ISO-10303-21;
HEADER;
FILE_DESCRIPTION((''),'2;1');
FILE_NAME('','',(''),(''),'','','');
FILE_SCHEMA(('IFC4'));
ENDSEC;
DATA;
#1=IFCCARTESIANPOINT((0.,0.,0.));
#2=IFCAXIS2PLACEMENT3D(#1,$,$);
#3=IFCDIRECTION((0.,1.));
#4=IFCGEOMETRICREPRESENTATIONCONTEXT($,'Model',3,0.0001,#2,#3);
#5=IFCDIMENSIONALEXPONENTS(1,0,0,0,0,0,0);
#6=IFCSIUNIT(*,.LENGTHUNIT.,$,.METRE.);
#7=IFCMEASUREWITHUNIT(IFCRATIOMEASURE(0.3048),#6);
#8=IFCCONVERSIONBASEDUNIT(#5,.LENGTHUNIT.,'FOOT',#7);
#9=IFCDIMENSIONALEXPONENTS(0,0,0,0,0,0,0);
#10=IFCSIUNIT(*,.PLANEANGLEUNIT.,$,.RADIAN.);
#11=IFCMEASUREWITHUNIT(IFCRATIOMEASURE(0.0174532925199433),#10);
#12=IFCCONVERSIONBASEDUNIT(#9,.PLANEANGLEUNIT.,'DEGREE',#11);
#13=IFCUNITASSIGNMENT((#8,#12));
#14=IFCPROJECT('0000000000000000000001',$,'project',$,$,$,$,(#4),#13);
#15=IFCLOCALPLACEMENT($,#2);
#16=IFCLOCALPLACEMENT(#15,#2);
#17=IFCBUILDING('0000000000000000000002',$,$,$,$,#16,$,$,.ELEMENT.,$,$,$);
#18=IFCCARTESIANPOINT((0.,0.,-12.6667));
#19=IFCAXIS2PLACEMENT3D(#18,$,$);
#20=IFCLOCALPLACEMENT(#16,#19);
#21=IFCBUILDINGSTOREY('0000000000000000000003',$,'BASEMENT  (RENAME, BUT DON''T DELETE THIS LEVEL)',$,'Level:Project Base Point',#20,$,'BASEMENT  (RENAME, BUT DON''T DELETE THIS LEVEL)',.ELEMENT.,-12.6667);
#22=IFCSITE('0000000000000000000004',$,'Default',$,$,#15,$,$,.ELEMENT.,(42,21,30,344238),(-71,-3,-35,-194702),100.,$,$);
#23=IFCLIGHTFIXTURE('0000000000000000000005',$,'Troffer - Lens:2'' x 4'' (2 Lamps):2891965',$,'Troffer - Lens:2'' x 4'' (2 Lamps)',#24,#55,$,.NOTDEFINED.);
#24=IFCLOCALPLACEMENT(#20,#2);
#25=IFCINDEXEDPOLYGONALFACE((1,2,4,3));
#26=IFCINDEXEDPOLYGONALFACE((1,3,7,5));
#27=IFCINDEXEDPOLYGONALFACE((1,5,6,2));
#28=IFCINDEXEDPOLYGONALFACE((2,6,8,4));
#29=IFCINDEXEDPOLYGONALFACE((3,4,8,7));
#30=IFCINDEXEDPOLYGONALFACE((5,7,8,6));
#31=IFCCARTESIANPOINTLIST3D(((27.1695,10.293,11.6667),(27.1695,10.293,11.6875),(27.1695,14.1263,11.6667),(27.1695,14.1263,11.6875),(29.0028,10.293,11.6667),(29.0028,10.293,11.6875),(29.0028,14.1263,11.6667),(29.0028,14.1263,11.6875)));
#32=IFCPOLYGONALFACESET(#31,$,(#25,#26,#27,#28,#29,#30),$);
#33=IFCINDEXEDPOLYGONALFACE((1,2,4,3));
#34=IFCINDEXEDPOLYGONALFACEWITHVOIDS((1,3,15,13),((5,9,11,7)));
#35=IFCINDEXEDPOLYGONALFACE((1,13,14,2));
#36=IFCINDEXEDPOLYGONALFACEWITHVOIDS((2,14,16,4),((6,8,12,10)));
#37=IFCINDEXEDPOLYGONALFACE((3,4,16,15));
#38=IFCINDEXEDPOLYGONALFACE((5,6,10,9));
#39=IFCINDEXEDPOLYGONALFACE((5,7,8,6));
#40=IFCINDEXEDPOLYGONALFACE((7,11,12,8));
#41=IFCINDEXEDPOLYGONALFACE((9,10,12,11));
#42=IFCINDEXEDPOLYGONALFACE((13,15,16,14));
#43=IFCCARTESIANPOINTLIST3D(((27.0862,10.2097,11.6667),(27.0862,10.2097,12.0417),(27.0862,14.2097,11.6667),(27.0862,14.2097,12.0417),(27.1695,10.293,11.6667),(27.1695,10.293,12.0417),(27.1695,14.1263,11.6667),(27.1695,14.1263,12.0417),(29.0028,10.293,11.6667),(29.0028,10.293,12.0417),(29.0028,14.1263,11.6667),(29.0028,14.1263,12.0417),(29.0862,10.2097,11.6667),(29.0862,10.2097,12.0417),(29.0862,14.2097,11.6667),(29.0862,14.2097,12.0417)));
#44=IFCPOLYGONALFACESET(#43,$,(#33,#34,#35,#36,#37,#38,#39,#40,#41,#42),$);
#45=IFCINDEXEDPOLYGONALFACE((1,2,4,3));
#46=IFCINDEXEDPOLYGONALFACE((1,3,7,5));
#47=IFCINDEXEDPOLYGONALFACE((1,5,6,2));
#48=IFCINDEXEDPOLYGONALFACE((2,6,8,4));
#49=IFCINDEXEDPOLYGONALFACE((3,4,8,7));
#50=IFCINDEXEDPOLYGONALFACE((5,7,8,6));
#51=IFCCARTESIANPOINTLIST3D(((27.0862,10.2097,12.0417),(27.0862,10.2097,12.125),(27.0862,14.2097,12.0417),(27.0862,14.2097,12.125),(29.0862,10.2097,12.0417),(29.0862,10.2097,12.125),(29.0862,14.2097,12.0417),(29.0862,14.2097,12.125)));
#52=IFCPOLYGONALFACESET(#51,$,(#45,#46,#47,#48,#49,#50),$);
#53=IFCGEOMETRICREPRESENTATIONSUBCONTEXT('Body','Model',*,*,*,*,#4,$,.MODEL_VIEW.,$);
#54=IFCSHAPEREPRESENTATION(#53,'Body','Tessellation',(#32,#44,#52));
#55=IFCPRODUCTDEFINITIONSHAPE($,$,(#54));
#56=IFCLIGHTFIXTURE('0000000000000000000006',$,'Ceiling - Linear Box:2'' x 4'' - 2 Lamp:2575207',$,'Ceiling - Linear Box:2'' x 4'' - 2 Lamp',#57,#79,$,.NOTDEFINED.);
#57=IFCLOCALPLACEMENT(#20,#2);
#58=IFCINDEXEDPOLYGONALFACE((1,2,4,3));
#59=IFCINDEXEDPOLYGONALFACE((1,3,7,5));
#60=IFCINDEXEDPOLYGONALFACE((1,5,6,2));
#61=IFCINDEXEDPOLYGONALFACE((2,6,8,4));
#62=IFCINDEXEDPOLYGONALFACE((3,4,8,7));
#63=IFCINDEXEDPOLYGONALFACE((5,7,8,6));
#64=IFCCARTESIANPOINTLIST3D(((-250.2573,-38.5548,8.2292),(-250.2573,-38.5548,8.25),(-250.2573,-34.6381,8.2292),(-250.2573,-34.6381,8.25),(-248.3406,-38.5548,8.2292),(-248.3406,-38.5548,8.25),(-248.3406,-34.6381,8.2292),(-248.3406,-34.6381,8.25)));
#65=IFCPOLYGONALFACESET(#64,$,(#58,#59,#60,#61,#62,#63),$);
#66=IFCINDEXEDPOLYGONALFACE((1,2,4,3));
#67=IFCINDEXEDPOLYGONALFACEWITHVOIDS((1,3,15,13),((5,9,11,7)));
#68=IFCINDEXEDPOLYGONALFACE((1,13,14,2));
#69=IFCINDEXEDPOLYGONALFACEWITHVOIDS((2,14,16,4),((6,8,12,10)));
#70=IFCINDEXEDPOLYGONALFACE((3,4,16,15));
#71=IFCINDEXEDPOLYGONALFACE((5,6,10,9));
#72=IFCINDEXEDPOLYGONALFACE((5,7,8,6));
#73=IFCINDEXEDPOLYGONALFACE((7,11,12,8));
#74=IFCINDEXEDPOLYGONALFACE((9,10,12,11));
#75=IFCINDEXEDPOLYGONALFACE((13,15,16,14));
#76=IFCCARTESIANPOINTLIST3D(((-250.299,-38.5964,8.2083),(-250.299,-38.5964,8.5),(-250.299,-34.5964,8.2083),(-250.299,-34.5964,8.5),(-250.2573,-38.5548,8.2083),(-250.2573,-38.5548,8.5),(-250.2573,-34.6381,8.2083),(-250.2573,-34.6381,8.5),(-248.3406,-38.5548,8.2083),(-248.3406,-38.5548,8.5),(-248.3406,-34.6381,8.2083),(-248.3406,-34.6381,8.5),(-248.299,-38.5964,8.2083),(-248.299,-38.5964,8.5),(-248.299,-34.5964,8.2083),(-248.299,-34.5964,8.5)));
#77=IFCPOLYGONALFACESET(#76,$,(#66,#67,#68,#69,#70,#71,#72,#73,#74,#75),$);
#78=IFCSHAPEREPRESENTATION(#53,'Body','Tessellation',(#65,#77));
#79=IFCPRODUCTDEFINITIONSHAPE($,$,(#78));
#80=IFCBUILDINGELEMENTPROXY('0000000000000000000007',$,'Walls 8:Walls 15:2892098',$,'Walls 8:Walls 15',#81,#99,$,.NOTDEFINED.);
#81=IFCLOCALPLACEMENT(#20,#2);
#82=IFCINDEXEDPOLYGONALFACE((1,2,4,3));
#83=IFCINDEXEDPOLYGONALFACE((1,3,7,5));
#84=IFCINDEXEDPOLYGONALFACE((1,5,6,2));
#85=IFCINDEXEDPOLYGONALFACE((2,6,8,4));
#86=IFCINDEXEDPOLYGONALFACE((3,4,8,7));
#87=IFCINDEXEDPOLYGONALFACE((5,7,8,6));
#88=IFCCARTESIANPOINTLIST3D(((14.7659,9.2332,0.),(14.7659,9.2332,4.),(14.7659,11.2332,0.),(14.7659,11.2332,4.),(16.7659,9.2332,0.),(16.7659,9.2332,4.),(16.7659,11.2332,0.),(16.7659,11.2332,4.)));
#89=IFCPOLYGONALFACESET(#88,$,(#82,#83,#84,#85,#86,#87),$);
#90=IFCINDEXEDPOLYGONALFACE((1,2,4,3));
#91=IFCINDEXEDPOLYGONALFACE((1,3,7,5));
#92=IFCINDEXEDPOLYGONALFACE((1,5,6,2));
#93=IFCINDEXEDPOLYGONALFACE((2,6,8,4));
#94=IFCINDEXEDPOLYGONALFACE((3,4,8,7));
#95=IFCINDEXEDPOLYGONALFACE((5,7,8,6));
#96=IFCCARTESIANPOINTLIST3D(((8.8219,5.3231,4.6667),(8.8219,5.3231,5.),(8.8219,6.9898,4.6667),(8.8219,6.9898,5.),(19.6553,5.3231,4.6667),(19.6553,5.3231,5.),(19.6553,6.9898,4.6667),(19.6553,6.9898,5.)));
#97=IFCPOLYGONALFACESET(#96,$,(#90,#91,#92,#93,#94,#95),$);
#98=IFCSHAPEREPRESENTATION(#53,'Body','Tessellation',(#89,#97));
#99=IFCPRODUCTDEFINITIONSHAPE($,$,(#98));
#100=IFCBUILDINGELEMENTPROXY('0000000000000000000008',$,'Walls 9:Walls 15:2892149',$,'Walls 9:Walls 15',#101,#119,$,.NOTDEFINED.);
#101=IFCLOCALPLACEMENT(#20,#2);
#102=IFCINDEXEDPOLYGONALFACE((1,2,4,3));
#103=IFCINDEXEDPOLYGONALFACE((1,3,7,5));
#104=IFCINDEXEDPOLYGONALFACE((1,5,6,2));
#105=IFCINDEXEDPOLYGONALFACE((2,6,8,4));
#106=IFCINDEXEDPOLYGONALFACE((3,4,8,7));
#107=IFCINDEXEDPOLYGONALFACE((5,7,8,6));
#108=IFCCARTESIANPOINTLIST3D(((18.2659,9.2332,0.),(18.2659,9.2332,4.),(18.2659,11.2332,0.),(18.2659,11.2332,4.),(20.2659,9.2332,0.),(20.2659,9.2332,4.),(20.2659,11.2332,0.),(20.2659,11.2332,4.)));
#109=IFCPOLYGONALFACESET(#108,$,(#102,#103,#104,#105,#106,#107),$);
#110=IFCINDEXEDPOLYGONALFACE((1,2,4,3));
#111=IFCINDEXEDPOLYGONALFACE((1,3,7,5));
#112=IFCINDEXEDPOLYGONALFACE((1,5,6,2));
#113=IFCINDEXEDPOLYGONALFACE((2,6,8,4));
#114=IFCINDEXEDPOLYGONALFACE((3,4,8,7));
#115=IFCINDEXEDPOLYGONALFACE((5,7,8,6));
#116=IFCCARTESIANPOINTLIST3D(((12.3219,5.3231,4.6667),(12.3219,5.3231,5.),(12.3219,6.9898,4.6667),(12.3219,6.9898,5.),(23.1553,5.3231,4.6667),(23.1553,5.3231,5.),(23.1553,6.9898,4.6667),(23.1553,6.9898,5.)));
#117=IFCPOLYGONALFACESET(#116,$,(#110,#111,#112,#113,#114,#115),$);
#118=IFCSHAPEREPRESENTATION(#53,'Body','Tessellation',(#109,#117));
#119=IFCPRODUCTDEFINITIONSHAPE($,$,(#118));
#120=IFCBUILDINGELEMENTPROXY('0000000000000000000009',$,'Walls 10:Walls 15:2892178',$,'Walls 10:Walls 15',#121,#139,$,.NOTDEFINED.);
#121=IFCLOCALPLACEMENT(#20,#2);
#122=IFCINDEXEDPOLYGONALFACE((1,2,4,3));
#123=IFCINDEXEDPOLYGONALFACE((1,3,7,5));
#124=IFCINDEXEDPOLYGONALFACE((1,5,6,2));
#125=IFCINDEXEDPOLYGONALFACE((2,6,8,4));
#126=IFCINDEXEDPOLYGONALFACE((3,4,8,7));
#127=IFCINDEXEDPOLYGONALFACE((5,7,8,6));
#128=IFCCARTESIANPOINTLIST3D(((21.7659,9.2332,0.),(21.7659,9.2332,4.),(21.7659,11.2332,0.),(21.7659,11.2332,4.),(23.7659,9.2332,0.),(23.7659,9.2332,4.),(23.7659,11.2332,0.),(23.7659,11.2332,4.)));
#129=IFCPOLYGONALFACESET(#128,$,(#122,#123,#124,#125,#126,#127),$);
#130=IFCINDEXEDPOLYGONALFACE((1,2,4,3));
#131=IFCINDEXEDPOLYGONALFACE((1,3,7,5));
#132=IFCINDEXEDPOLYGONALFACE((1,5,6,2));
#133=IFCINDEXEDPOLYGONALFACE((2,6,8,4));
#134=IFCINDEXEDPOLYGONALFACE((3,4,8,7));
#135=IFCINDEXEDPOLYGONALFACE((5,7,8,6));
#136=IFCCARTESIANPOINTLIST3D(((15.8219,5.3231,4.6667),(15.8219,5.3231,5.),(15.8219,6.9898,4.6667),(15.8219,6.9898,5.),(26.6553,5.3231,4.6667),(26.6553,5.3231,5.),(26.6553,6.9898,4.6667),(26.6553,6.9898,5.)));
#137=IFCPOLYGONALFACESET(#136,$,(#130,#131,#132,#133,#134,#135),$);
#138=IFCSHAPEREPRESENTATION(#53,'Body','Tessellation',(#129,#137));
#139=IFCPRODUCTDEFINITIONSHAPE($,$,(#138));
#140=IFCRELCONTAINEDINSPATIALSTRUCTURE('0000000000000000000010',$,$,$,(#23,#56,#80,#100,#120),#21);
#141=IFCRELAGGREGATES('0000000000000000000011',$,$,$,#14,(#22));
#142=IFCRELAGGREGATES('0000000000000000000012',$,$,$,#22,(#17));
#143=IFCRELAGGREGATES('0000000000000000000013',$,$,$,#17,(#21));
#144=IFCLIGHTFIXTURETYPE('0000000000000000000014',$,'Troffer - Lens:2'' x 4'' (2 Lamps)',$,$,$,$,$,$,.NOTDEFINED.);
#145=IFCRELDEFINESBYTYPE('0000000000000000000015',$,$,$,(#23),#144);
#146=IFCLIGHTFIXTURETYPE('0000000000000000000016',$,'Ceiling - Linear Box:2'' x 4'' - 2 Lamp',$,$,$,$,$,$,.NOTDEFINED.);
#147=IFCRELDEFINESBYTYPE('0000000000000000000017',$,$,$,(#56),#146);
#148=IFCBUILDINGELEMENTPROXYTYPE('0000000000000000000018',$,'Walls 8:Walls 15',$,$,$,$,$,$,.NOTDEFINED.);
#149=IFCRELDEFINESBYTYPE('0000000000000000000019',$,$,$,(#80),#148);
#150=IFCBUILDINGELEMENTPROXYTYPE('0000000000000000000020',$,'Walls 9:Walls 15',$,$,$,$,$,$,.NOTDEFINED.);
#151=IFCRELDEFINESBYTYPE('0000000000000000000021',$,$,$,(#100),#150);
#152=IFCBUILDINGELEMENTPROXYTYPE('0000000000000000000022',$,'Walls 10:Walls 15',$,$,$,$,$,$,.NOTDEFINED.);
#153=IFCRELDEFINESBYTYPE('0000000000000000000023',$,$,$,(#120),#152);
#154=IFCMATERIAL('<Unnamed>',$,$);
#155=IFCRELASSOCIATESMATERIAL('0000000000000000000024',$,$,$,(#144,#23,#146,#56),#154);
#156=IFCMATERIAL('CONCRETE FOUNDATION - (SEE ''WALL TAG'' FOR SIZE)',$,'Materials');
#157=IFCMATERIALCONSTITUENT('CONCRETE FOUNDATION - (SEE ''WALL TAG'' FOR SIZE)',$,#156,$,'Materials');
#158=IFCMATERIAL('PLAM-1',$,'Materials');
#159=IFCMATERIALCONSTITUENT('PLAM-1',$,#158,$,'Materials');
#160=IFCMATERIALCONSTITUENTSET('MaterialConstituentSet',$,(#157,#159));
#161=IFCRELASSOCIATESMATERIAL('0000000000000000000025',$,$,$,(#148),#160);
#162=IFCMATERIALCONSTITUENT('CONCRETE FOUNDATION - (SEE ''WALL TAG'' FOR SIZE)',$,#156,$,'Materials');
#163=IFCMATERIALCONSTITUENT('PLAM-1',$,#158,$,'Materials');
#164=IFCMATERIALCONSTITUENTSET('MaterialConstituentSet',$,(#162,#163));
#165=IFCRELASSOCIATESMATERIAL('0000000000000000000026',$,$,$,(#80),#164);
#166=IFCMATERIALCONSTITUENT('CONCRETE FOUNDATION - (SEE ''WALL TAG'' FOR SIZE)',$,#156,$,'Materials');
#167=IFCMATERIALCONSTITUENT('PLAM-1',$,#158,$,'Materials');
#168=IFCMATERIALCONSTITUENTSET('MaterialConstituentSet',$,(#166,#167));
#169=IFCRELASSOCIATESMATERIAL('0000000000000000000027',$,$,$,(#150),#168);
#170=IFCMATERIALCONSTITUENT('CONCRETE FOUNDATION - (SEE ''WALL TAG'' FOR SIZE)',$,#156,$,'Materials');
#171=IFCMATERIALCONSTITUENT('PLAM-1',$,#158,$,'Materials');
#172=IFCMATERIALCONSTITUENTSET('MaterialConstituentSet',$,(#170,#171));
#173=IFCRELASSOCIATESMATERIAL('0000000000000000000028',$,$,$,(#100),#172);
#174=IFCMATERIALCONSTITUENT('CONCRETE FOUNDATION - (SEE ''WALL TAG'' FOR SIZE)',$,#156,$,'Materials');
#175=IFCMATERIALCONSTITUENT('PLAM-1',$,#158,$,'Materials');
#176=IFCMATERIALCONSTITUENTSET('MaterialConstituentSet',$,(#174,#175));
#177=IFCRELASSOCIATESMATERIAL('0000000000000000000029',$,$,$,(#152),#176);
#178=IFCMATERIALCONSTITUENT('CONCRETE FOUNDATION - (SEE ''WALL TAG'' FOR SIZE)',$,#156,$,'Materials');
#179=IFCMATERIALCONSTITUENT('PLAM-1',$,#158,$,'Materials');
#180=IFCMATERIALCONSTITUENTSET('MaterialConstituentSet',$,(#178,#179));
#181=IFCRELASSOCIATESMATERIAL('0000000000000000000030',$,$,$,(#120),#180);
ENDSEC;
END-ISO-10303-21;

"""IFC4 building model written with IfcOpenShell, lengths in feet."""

from ifc_helpers import new_model, entity, si_unit, converted_unit, direction, frame, frame_2d, origin, origin_2d_with_axis, place, context, subcontext, project, spatial, polyline, rectangle, outline, extrude, source, transform, mapped, material, constituent, constituent_set, type_object, type_shapes, element, save


model = new_model("IFC4")

# Units and contexts
model_context = context("Model", 3, precision=0.0001, world=origin(), true_north=direction((0.0, 1.0)))
body_context = subcontext(model_context, "Body", "Model", "MODEL_VIEW")
ifc_project = project(units=[converted_unit("LENGTHUNIT", "FOOT", entity("IfcRatioMeasure", 0.3048), si_unit("LENGTHUNIT", "METRE"), dimensions=[1, 0, 0, 0, 0, 0, 0]), converted_unit("PLANEANGLEUNIT", "DEGREE", entity("IfcRatioMeasure", 0.0174532925199433), si_unit("PLANEANGLEUNIT", "RADIAN"), dimensions=[0, 0, 0, 0, 0, 0, 0])], contexts=[model_context])

# Site, building, storey
site_placement = place(None, origin())
site = spatial("IfcSite", under=ifc_project, at=site_placement, Name="Default", CompositionType="ELEMENT", RefLatitude=(42, 21, 30, 344238), RefLongitude=(-71, -3, -35, -194702), RefElevation=100.0)
building_placement = place(site_placement, origin())
building = spatial("IfcBuilding", under=site, at=building_placement, CompositionType="ELEMENT")
storey_placement = place(building_placement, frame((0.0, 0.0, -12.6667)))
storey = spatial("IfcBuildingStorey", under=building, at=storey_placement, Name="BASEMENT  (RENAME, BUT DON'T DELETE THIS LEVEL)", ObjectType="Level:Project Base Point", LongName="BASEMENT  (RENAME, BUT DON'T DELETE THIS LEVEL)", CompositionType="ELEMENT", Elevation=-12.6667)

# Shared definitions
ifc_material_1 = material(Name="CONCRETE FOUNDATION - (SEE 'WALL TAG' FOR SIZE)", Category="Materials")
ifc_material_2 = material(Name="PLAM-1", Category="Materials")

# Light fixtures
ifc_material_3 = material(Name="<Unnamed>")
light_fixture_type_1 = type_object("IfcLightFixtureType", Name="Troffer - Lens:2' x 4' (2 Lamps)", PredefinedType="NOTDEFINED", material=ifc_material_3)
shared_shape_1 = source(origin(), body_context, "Body", "SweptSolid", [
    extrude(rectangle(XDim=3.8333, YDim=1.8333, at=origin_2d_with_axis()), frame((2.0, 1.0, 0.0), z_axis=(0.0, 0.0, 1.0), x_axis=(-1.0, 0.0, 0.0)), (0.0, 0.0, 1.0), 0.0208),
    extrude(outline(polyline([(-2.0, -1.0), (2.0, -1.0), (2.0, 1.0), (-2.0, 1.0), (-2.0, -1.0)]), holes=[polyline([(-1.9167, -0.9167), (-1.9167, 0.9167), (1.9167, 0.9167), (1.9167, -0.9167), (-1.9167, -0.9167)])]), frame((2.0, 1.0, 0.0), z_axis=(0.0, 0.0, 1.0), x_axis=(-1.0, 0.0, 0.0)), (0.0, 0.0, 1.0), 0.375),
    extrude(rectangle(XDim=4.0, YDim=2.0, at=frame_2d((0.0, 0.0), x_axis=(1.0, 0.0))), frame((2.0, 1.0, 0.375), z_axis=(0.0, 0.0, 1.0), x_axis=(-1.0, 0.0, 0.0)), (0.0, 0.0, 1.0), 0.0833),
])
type_shapes(light_fixture_type_1, [shared_shape_1])
for number, where, z_axis, x_axis, name in (
    (1, (29.0862, 10.2097, 11.6667), (0.0, 0.0, 1.0), (0.0, 1.0, 0.0), "Troffer - Lens:2' x 4' (2 Lamps):2891965"),
):
    element("IfcLightFixture", number, at=place(storey_placement, frame(where, z_axis=z_axis, x_axis=x_axis)), inside=storey, type_object=light_fixture_type_1, material=ifc_material_3, Name=name, ObjectType="Troffer - Lens:2' x 4' (2 Lamps)", PredefinedType="NOTDEFINED", context=body_context, shape_type="MappedRepresentation", body=[
        mapped(shared_shape_1, transform((0.0, 0.0, 0.0), scale=1.0)),
    ])
light_fixture_type_2 = type_object("IfcLightFixtureType", Name="Ceiling - Linear Box:2' x 4' - 2 Lamp", PredefinedType="NOTDEFINED", material=ifc_material_3)
shared_shape_2 = source(origin(), body_context, "Body", "SweptSolid", [
    extrude(rectangle(XDim=3.9167, YDim=1.9167, at=origin_2d_with_axis()), frame((2.0, 1.0, 0.0208), z_axis=(0.0, 0.0, 1.0), x_axis=(-1.0, 0.0, 0.0)), (0.0, 0.0, 1.0), 0.0208),
    extrude(outline(polyline([(-2.0, -1.0), (2.0, -1.0), (2.0, 1.0), (-2.0, 1.0), (-2.0, -1.0)]), holes=[polyline([(-1.9583, -0.9583), (-1.9583, 0.9583), (1.9583, 0.9583), (1.9583, -0.9583), (-1.9583, -0.9583)])]), frame((2.0, 1.0, 0.0), z_axis=(0.0, 0.0, 1.0), x_axis=(-1.0, 0.0, 0.0)), (0.0, 0.0, 1.0), 0.2917),
])
type_shapes(light_fixture_type_2, [shared_shape_2])
light_fixture_placement = place(storey_placement, frame((-248.299, -38.5964, 8.2083), z_axis=(0.0, 0.0, 1.0), x_axis=(0.0, 1.0, 0.0)))
element("IfcLightFixture", 2, at=light_fixture_placement, inside=storey, type_object=light_fixture_type_2, material=ifc_material_3, Name="Ceiling - Linear Box:2' x 4' - 2 Lamp:2575207", ObjectType="Ceiling - Linear Box:2' x 4' - 2 Lamp", PredefinedType="NOTDEFINED", context=body_context, shape_type="MappedRepresentation", body=[
    mapped(shared_shape_2, transform((0.0, 0.0, 0.0), scale=1.0)),
])

# Building element proxies
ifc_constituent_1 = constituent(ifc_material_1, Name="CONCRETE FOUNDATION - (SEE 'WALL TAG' FOR SIZE)", Category="Materials")
ifc_constituent_2 = constituent(ifc_material_2, Name="PLAM-1", Category="Materials")
ifc_constituent_set_1 = constituent_set(constituents=[ifc_constituent_1, ifc_constituent_2], Name="MaterialConstituentSet")
ifc_constituent_3 = constituent(ifc_material_1, Name="CONCRETE FOUNDATION - (SEE 'WALL TAG' FOR SIZE)", Category="Materials")
ifc_constituent_4 = constituent(ifc_material_2, Name="PLAM-1", Category="Materials")
ifc_constituent_set_2 = constituent_set(constituents=[ifc_constituent_3, ifc_constituent_4], Name="MaterialConstituentSet")
building_element_proxy_type_1 = type_object("IfcBuildingElementProxyType", Name="Walls 8:Walls 15", PredefinedType="NOTDEFINED", material=ifc_constituent_set_2)
shared_shape_3 = source(origin(), body_context, "Body", "SweptSolid", [
    extrude(rectangle(XDim=2.0, YDim=2.0, at=origin_2d_with_axis()), frame((6.944, 4.9101, 0.0), z_axis=(0.0, 0.0, 1.0), x_axis=(-1.0, 0.0, 0.0)), (0.0, 0.0, 1.0), 4.0),
    extrude(rectangle(XDim=10.8333, YDim=1.6667, at=frame_2d((0.0, 0.0), x_axis=(1.0, 0.0))), frame((5.4167, 0.8333, 4.6667), z_axis=(0.0, 0.0, 1.0), x_axis=(-1.0, 0.0, 0.0)), (0.0, 0.0, 1.0), 0.3333),
])
type_shapes(building_element_proxy_type_1, [shared_shape_3])
proxy_1_placement = place(storey_placement, frame((8.8219, 5.3231, 0.0)))
element("IfcBuildingElementProxy", 3, at=proxy_1_placement, inside=storey, type_object=building_element_proxy_type_1, material=ifc_constituent_set_1, Name="Walls 8:Walls 15:2892098", ObjectType="Walls 8:Walls 15", PredefinedType="NOTDEFINED", context=body_context, shape_type="MappedRepresentation", body=[
    mapped(shared_shape_3, transform((0.0, 0.0, 0.0), scale=1.0)),
])
ifc_constituent_5 = constituent(ifc_material_1, Name="CONCRETE FOUNDATION - (SEE 'WALL TAG' FOR SIZE)", Category="Materials")
ifc_constituent_6 = constituent(ifc_material_2, Name="PLAM-1", Category="Materials")
ifc_constituent_set_3 = constituent_set(constituents=[ifc_constituent_5, ifc_constituent_6], Name="MaterialConstituentSet")
ifc_constituent_7 = constituent(ifc_material_1, Name="CONCRETE FOUNDATION - (SEE 'WALL TAG' FOR SIZE)", Category="Materials")
ifc_constituent_8 = constituent(ifc_material_2, Name="PLAM-1", Category="Materials")
ifc_constituent_set_4 = constituent_set(constituents=[ifc_constituent_7, ifc_constituent_8], Name="MaterialConstituentSet")
building_element_proxy_type_2 = type_object("IfcBuildingElementProxyType", Name="Walls 9:Walls 15", PredefinedType="NOTDEFINED", material=ifc_constituent_set_4)
shared_shape_4 = source(origin(), body_context, "Body", "SweptSolid", [
    extrude(rectangle(XDim=2.0, YDim=2.0, at=origin_2d_with_axis()), frame((6.944, 4.9101, 0.0), z_axis=(0.0, 0.0, 1.0), x_axis=(-1.0, 0.0, 0.0)), (0.0, 0.0, 1.0), 4.0),
    extrude(rectangle(XDim=10.8333, YDim=1.6667, at=frame_2d((0.0, 0.0), x_axis=(1.0, 0.0))), frame((5.4167, 0.8333, 4.6667), z_axis=(0.0, 0.0, 1.0), x_axis=(-1.0, 0.0, 0.0)), (0.0, 0.0, 1.0), 0.3333),
])
type_shapes(building_element_proxy_type_2, [shared_shape_4])
proxy_2_placement = place(storey_placement, frame((12.3219, 5.3231, 0.0)))
element("IfcBuildingElementProxy", 4, at=proxy_2_placement, inside=storey, type_object=building_element_proxy_type_2, material=ifc_constituent_set_3, Name="Walls 9:Walls 15:2892149", ObjectType="Walls 9:Walls 15", PredefinedType="NOTDEFINED", context=body_context, shape_type="MappedRepresentation", body=[
    mapped(shared_shape_4, transform((0.0, 0.0, 0.0), scale=1.0)),
])
ifc_constituent_9 = constituent(ifc_material_1, Name="CONCRETE FOUNDATION - (SEE 'WALL TAG' FOR SIZE)", Category="Materials")
ifc_constituent_10 = constituent(ifc_material_2, Name="PLAM-1", Category="Materials")
ifc_constituent_set_5 = constituent_set(constituents=[ifc_constituent_9, ifc_constituent_10], Name="MaterialConstituentSet")
ifc_constituent_11 = constituent(ifc_material_1, Name="CONCRETE FOUNDATION - (SEE 'WALL TAG' FOR SIZE)", Category="Materials")
ifc_constituent_12 = constituent(ifc_material_2, Name="PLAM-1", Category="Materials")
ifc_constituent_set_6 = constituent_set(constituents=[ifc_constituent_11, ifc_constituent_12], Name="MaterialConstituentSet")
building_element_proxy_type_3 = type_object("IfcBuildingElementProxyType", Name="Walls 10:Walls 15", PredefinedType="NOTDEFINED", material=ifc_constituent_set_6)
shared_shape_5 = source(origin(), body_context, "Body", "SweptSolid", [
    extrude(rectangle(XDim=2.0, YDim=2.0, at=origin_2d_with_axis()), frame((6.944, 4.9101, 0.0), z_axis=(0.0, 0.0, 1.0), x_axis=(-1.0, 0.0, 0.0)), (0.0, 0.0, 1.0), 4.0),
    extrude(rectangle(XDim=10.8333, YDim=1.6667, at=frame_2d((0.0, 0.0), x_axis=(1.0, 0.0))), frame((5.4167, 0.8333, 4.6667), z_axis=(0.0, 0.0, 1.0), x_axis=(-1.0, 0.0, 0.0)), (0.0, 0.0, 1.0), 0.3333),
])
type_shapes(building_element_proxy_type_3, [shared_shape_5])
proxy_3_placement = place(storey_placement, frame((15.8219, 5.3231, 0.0)))
element("IfcBuildingElementProxy", 5, at=proxy_3_placement, inside=storey, type_object=building_element_proxy_type_3, material=ifc_constituent_set_5, Name="Walls 10:Walls 15:2892178", ObjectType="Walls 10:Walls 15", PredefinedType="NOTDEFINED", context=body_context, shape_type="MappedRepresentation", body=[
    mapped(shared_shape_5, transform((0.0, 0.0, 0.0), scale=1.0)),
])

save(model, "model.ifc")
